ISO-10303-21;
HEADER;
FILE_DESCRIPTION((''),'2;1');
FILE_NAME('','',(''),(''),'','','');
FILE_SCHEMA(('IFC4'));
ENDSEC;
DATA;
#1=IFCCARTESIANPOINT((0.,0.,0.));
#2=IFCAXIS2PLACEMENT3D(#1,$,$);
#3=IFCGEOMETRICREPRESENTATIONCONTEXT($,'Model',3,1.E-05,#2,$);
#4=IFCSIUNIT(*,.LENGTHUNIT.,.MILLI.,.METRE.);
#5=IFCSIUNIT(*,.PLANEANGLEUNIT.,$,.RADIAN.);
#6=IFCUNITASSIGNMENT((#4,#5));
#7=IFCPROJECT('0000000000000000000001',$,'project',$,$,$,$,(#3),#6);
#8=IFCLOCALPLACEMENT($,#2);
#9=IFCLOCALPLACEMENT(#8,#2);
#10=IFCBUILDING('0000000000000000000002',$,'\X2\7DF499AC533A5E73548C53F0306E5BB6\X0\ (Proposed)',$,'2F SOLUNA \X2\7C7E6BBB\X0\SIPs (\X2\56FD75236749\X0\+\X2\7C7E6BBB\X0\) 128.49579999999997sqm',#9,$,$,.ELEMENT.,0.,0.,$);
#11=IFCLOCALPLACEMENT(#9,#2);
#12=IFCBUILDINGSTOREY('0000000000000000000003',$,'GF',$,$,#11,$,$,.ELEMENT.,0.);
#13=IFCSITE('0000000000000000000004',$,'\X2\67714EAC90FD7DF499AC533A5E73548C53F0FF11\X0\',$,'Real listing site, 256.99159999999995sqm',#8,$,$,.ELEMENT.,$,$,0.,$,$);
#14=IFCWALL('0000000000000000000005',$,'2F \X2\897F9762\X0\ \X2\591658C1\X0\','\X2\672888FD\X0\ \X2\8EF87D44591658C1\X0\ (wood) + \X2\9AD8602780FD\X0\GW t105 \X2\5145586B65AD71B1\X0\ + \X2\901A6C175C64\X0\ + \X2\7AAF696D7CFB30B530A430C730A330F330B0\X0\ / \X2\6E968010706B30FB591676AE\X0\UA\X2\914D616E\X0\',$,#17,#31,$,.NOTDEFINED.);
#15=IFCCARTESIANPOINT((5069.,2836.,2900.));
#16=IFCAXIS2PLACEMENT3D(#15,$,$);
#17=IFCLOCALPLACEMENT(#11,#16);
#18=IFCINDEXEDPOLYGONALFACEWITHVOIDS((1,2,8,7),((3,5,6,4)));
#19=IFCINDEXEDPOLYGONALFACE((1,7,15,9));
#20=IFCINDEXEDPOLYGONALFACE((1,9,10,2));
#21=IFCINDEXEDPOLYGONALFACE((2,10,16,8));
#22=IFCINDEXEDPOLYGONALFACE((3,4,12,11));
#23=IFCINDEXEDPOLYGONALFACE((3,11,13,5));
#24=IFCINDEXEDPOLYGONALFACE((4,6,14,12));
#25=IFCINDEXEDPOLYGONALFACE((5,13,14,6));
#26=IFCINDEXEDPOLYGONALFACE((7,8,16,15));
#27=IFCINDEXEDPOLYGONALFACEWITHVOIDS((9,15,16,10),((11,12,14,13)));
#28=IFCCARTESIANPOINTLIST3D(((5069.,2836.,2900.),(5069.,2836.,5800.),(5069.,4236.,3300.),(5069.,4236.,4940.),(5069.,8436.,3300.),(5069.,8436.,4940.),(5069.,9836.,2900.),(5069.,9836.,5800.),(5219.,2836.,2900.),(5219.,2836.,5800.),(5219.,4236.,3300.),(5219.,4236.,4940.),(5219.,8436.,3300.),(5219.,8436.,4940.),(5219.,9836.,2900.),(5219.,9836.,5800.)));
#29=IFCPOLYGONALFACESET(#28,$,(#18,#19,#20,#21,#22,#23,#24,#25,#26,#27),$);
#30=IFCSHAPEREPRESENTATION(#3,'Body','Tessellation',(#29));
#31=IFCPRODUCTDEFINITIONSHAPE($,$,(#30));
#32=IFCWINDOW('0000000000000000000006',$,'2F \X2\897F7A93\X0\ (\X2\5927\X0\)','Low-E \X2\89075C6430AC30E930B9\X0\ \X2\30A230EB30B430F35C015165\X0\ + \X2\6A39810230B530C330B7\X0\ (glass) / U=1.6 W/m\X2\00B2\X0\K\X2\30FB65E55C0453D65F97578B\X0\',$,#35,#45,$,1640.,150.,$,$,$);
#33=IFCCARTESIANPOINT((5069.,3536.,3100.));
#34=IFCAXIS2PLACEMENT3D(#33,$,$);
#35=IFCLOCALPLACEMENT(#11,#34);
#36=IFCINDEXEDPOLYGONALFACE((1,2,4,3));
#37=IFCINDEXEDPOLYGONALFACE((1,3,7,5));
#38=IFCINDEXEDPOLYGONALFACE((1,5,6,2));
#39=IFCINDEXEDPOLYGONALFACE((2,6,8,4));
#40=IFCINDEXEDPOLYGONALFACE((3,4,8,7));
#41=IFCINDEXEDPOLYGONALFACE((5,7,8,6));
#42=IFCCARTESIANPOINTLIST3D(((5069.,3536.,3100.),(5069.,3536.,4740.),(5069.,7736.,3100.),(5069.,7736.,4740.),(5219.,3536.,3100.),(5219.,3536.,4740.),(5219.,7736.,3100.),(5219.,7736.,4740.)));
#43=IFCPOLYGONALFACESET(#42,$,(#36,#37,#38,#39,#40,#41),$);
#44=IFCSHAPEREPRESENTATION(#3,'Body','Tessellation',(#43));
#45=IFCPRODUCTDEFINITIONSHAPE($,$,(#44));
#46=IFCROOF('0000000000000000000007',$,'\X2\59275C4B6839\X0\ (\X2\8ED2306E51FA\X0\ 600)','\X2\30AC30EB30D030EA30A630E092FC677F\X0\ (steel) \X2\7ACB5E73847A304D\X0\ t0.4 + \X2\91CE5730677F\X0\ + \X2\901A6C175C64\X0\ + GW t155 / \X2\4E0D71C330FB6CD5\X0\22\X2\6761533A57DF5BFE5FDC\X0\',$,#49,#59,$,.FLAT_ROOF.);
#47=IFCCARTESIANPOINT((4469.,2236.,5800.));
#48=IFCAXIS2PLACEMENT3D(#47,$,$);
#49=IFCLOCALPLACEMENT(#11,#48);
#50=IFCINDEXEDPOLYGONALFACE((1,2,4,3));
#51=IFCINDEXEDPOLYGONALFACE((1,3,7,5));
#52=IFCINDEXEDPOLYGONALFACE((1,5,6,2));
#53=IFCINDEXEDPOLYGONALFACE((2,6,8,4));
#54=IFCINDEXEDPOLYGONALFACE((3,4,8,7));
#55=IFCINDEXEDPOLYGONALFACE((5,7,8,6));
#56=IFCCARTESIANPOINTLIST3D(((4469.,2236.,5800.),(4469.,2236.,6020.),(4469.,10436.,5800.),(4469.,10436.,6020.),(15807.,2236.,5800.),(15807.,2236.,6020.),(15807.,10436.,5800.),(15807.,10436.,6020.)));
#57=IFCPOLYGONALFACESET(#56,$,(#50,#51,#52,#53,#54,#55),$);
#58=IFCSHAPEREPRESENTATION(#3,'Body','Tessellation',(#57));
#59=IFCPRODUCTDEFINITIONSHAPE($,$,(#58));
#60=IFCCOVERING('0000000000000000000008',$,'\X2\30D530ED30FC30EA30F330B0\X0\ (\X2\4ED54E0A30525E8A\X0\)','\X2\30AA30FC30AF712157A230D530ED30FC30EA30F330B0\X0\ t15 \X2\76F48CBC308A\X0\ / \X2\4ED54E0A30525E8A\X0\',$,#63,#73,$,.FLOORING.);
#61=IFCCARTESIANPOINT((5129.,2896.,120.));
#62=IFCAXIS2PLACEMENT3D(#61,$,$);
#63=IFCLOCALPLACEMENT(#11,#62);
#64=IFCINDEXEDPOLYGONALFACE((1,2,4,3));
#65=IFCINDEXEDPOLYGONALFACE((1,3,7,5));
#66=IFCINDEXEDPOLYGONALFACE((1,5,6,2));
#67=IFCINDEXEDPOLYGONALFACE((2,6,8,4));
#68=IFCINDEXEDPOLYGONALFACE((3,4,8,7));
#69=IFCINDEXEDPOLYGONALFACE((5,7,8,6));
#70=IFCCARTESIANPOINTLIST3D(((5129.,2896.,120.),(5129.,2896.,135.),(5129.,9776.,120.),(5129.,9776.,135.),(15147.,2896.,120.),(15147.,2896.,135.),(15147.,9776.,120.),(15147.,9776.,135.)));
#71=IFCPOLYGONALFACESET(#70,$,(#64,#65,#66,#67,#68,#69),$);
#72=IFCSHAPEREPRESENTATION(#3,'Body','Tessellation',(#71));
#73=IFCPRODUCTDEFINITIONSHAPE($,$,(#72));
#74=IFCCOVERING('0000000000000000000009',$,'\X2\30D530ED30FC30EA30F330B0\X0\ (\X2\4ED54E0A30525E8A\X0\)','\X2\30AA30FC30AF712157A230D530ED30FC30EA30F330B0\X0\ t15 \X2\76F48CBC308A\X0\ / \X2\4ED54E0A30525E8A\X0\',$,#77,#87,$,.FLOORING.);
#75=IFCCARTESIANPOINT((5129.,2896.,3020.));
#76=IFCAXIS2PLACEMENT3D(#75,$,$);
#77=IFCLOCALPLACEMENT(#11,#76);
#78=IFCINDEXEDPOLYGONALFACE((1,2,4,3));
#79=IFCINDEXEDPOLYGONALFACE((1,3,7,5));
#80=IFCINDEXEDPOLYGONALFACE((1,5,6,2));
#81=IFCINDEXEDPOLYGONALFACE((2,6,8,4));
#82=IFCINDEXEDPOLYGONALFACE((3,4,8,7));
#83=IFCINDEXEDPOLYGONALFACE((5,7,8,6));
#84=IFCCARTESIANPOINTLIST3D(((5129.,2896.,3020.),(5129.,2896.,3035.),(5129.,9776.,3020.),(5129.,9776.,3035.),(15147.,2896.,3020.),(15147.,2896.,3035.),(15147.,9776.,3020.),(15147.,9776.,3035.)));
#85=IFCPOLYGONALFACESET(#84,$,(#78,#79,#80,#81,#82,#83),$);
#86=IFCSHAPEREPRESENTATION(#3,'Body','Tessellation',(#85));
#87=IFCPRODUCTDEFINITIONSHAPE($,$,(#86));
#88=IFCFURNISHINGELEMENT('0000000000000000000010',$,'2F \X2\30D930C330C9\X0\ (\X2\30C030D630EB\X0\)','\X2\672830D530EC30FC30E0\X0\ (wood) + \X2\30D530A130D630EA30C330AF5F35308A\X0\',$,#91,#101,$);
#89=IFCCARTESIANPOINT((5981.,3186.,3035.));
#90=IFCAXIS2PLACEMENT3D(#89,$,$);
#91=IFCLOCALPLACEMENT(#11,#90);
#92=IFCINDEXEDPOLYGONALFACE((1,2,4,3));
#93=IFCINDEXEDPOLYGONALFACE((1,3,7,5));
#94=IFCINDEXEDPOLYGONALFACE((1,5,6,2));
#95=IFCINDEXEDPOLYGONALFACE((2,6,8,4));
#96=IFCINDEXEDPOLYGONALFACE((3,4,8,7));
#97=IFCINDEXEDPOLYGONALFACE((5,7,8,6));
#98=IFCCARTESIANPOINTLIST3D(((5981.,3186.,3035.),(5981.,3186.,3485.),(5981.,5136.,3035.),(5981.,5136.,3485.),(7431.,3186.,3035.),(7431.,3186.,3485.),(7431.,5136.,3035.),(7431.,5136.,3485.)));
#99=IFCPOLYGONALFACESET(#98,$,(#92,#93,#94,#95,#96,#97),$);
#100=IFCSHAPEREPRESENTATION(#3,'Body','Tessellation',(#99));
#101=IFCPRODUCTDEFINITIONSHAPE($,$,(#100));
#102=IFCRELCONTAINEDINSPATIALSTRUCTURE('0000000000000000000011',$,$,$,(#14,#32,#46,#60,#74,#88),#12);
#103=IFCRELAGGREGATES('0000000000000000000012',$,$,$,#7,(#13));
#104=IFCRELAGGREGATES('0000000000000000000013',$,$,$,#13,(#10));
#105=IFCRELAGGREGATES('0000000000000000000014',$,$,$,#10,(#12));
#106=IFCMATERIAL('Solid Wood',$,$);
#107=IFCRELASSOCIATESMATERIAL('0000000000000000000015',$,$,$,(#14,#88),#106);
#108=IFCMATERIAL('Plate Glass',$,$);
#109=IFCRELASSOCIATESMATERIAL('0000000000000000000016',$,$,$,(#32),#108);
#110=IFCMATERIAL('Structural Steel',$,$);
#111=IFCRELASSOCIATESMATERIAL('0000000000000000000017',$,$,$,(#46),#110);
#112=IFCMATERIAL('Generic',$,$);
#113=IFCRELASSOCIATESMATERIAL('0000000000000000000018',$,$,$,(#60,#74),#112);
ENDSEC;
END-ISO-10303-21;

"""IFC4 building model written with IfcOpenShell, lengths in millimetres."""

from ifc_helpers import new_model, si_unit, frame, frame_2d, origin, place, context, project, spatial, rectangle, extrude, material, element, fill, save


model = new_model("IFC4")

# Units and contexts
model_context = context("Model", 3, precision=1e-05, world=origin())
ifc_project = project(units=[si_unit("LENGTHUNIT", "METRE", prefix="MILLI"), si_unit("PLANEANGLEUNIT", "RADIAN")], contexts=[model_context])

# Site, building, storey
site_placement = place(None, origin())
site = spatial("IfcSite", under=ifc_project, at=site_placement, Name="東京都練馬区平和台１", ObjectType="Real listing site, 256.99159999999995sqm", CompositionType="ELEMENT", RefElevation=0.0)
building_placement = place(site_placement, origin())
building = spatial("IfcBuilding", under=site, at=building_placement, Name="練馬区平和台の家 (Proposed)", ObjectType="2F SOLUNA 籾殻SIPs (国産杉+籾殻) 128.49579999999997sqm", CompositionType="ELEMENT", ElevationOfRefHeight=0.0, ElevationOfTerrain=0.0)
storey_placement = place(building_placement, origin())
storey = spatial("IfcBuildingStorey", under=building, at=storey_placement, Name="GF", CompositionType="ELEMENT", Elevation=0.0)

# Shared definitions
ifc_material_1 = material(Name="Solid Wood")

# Shared definitions
ifc_material_2 = material(Name="Plate Glass")

# Wall, opening, window
wall_1_placement = place(storey_placement, frame((5069.0, 2836.0, 2900.0)))
wall_1 = element("IfcWall", 1, at=wall_1_placement, inside=storey, material=ifc_material_1, Name="2F 西面 外壁", Description="木製 軸組外壁 (wood) + 高性能GW t105 充填断熱 + 通気層 + 窯業系サイディング / 準耐火・外皮UA配慮", PredefinedType="NOTDEFINED", context=model_context, shape_type="SweptSolid", body=[
    extrude(rectangle(XDim=150.0, YDim=7000.0, at=frame_2d((75.0, 3500.0))), frame((5069.0, 2836.0, 2900.0)), (0.0, 0.0, 1.0), 2900.0),
])
opening_1_placement = place(storey_placement, frame((5069.0, 3536.0, 3100.0)))
opening_1 = element("IfcOpeningElement", 2, at=opening_1_placement, cuts=wall_1, PredefinedType="NOTDEFINED", context=model_context, shape_type="SweptSolid", body=[
    extrude(rectangle(XDim=150.0, YDim=4200.0, at=frame_2d((75.0, 2100.0))), frame((5069.0, 3536.0, 3100.0)), (0.0, 0.0, 1.0), 1640.0),
])
window_1_placement = place(storey_placement, frame((5069.0, 3536.0, 3100.0)))
window_1 = element("IfcWindow", 3, at=window_1_placement, inside=storey, material=ifc_material_2, Name="2F 西窓 (大)", Description="Low-E 複層ガラス アルゴン封入 + 樹脂サッシ (glass) / U=1.6 W/m²K・日射取得型", OverallHeight=1640.0, OverallWidth=150.0, context=model_context, shape_type="SweptSolid", body=[
    extrude(rectangle(XDim=150.0, YDim=4200.0, at=frame_2d((75.0, 2100.0))), frame((5069.0, 3536.0, 3100.0)), (0.0, 0.0, 1.0), 1640.0),
])
fill(opening_1, window_1)

# Roof
ifc_material_3 = material(Name="Structural Steel")
roof_placement = place(storey_placement, frame((4469.0, 2236.0, 5800.0)))
element("IfcRoof", 4, at=roof_placement, inside=storey, material=ifc_material_3, Name="大屋根 (軒の出 600)", Description="ガルバリウム鋼板 (steel) 立平葺き t0.4 + 野地板 + 通気層 + GW t155 / 不燃・法22条区域対応", PredefinedType="FLAT_ROOF", context=model_context, shape_type="SweptSolid", body=[
    extrude(rectangle(XDim=11338.0, YDim=8200.0, at=frame_2d((5669.0, 4100.0))), frame((4469.0, 2236.0, 5800.0)), (0.0, 0.0, 1.0), 220.0),
])

# Coverings
ifc_material_4 = material(Name="Generic")
covering_1_placement = place(storey_placement, frame((5129.0, 2896.0, 120.0)))
element("IfcCovering", 5, at=covering_1_placement, inside=storey, material=ifc_material_4, Name="フローリング (仕上げ床)", Description="オーク無垢フローリング t15 直貼り / 仕上げ床", PredefinedType="FLOORING", context=model_context, shape_type="SweptSolid", body=[
    extrude(rectangle(XDim=10018.0, YDim=6880.0, at=frame_2d((5009.0, 3440.0))), frame((5129.0, 2896.0, 120.0)), (0.0, 0.0, 1.0), 15.0),
])
covering_2_placement = place(storey_placement, frame((5129.0, 2896.0, 3020.0)))
element("IfcCovering", 6, at=covering_2_placement, inside=storey, material=ifc_material_4, Name="フローリング (仕上げ床)", Description="オーク無垢フローリング t15 直貼り / 仕上げ床", PredefinedType="FLOORING", context=model_context, shape_type="SweptSolid", body=[
    extrude(rectangle(XDim=10018.0, YDim=6880.0, at=frame_2d((5009.0, 3440.0))), frame((5129.0, 2896.0, 3020.0)), (0.0, 0.0, 1.0), 15.0),
])

# Furnishing element
furnishing_placement = place(storey_placement, frame((5981.0, 3186.0, 3035.0)))
element("IfcFurnishingElement", 7, at=furnishing_placement, inside=storey, material=ifc_material_1, Name="2F ベッド (ダブル)", Description="木フレーム (wood) + ファブリック張り", context=model_context, shape_type="SweptSolid", body=[
    extrude(rectangle(XDim=1450.0, YDim=1950.0, at=frame_2d((725.0, 975.0))), frame((5981.0, 3186.0, 3035.0)), (0.0, 0.0, 1.0), 450.0),
])

save(model, "model.ifc")
